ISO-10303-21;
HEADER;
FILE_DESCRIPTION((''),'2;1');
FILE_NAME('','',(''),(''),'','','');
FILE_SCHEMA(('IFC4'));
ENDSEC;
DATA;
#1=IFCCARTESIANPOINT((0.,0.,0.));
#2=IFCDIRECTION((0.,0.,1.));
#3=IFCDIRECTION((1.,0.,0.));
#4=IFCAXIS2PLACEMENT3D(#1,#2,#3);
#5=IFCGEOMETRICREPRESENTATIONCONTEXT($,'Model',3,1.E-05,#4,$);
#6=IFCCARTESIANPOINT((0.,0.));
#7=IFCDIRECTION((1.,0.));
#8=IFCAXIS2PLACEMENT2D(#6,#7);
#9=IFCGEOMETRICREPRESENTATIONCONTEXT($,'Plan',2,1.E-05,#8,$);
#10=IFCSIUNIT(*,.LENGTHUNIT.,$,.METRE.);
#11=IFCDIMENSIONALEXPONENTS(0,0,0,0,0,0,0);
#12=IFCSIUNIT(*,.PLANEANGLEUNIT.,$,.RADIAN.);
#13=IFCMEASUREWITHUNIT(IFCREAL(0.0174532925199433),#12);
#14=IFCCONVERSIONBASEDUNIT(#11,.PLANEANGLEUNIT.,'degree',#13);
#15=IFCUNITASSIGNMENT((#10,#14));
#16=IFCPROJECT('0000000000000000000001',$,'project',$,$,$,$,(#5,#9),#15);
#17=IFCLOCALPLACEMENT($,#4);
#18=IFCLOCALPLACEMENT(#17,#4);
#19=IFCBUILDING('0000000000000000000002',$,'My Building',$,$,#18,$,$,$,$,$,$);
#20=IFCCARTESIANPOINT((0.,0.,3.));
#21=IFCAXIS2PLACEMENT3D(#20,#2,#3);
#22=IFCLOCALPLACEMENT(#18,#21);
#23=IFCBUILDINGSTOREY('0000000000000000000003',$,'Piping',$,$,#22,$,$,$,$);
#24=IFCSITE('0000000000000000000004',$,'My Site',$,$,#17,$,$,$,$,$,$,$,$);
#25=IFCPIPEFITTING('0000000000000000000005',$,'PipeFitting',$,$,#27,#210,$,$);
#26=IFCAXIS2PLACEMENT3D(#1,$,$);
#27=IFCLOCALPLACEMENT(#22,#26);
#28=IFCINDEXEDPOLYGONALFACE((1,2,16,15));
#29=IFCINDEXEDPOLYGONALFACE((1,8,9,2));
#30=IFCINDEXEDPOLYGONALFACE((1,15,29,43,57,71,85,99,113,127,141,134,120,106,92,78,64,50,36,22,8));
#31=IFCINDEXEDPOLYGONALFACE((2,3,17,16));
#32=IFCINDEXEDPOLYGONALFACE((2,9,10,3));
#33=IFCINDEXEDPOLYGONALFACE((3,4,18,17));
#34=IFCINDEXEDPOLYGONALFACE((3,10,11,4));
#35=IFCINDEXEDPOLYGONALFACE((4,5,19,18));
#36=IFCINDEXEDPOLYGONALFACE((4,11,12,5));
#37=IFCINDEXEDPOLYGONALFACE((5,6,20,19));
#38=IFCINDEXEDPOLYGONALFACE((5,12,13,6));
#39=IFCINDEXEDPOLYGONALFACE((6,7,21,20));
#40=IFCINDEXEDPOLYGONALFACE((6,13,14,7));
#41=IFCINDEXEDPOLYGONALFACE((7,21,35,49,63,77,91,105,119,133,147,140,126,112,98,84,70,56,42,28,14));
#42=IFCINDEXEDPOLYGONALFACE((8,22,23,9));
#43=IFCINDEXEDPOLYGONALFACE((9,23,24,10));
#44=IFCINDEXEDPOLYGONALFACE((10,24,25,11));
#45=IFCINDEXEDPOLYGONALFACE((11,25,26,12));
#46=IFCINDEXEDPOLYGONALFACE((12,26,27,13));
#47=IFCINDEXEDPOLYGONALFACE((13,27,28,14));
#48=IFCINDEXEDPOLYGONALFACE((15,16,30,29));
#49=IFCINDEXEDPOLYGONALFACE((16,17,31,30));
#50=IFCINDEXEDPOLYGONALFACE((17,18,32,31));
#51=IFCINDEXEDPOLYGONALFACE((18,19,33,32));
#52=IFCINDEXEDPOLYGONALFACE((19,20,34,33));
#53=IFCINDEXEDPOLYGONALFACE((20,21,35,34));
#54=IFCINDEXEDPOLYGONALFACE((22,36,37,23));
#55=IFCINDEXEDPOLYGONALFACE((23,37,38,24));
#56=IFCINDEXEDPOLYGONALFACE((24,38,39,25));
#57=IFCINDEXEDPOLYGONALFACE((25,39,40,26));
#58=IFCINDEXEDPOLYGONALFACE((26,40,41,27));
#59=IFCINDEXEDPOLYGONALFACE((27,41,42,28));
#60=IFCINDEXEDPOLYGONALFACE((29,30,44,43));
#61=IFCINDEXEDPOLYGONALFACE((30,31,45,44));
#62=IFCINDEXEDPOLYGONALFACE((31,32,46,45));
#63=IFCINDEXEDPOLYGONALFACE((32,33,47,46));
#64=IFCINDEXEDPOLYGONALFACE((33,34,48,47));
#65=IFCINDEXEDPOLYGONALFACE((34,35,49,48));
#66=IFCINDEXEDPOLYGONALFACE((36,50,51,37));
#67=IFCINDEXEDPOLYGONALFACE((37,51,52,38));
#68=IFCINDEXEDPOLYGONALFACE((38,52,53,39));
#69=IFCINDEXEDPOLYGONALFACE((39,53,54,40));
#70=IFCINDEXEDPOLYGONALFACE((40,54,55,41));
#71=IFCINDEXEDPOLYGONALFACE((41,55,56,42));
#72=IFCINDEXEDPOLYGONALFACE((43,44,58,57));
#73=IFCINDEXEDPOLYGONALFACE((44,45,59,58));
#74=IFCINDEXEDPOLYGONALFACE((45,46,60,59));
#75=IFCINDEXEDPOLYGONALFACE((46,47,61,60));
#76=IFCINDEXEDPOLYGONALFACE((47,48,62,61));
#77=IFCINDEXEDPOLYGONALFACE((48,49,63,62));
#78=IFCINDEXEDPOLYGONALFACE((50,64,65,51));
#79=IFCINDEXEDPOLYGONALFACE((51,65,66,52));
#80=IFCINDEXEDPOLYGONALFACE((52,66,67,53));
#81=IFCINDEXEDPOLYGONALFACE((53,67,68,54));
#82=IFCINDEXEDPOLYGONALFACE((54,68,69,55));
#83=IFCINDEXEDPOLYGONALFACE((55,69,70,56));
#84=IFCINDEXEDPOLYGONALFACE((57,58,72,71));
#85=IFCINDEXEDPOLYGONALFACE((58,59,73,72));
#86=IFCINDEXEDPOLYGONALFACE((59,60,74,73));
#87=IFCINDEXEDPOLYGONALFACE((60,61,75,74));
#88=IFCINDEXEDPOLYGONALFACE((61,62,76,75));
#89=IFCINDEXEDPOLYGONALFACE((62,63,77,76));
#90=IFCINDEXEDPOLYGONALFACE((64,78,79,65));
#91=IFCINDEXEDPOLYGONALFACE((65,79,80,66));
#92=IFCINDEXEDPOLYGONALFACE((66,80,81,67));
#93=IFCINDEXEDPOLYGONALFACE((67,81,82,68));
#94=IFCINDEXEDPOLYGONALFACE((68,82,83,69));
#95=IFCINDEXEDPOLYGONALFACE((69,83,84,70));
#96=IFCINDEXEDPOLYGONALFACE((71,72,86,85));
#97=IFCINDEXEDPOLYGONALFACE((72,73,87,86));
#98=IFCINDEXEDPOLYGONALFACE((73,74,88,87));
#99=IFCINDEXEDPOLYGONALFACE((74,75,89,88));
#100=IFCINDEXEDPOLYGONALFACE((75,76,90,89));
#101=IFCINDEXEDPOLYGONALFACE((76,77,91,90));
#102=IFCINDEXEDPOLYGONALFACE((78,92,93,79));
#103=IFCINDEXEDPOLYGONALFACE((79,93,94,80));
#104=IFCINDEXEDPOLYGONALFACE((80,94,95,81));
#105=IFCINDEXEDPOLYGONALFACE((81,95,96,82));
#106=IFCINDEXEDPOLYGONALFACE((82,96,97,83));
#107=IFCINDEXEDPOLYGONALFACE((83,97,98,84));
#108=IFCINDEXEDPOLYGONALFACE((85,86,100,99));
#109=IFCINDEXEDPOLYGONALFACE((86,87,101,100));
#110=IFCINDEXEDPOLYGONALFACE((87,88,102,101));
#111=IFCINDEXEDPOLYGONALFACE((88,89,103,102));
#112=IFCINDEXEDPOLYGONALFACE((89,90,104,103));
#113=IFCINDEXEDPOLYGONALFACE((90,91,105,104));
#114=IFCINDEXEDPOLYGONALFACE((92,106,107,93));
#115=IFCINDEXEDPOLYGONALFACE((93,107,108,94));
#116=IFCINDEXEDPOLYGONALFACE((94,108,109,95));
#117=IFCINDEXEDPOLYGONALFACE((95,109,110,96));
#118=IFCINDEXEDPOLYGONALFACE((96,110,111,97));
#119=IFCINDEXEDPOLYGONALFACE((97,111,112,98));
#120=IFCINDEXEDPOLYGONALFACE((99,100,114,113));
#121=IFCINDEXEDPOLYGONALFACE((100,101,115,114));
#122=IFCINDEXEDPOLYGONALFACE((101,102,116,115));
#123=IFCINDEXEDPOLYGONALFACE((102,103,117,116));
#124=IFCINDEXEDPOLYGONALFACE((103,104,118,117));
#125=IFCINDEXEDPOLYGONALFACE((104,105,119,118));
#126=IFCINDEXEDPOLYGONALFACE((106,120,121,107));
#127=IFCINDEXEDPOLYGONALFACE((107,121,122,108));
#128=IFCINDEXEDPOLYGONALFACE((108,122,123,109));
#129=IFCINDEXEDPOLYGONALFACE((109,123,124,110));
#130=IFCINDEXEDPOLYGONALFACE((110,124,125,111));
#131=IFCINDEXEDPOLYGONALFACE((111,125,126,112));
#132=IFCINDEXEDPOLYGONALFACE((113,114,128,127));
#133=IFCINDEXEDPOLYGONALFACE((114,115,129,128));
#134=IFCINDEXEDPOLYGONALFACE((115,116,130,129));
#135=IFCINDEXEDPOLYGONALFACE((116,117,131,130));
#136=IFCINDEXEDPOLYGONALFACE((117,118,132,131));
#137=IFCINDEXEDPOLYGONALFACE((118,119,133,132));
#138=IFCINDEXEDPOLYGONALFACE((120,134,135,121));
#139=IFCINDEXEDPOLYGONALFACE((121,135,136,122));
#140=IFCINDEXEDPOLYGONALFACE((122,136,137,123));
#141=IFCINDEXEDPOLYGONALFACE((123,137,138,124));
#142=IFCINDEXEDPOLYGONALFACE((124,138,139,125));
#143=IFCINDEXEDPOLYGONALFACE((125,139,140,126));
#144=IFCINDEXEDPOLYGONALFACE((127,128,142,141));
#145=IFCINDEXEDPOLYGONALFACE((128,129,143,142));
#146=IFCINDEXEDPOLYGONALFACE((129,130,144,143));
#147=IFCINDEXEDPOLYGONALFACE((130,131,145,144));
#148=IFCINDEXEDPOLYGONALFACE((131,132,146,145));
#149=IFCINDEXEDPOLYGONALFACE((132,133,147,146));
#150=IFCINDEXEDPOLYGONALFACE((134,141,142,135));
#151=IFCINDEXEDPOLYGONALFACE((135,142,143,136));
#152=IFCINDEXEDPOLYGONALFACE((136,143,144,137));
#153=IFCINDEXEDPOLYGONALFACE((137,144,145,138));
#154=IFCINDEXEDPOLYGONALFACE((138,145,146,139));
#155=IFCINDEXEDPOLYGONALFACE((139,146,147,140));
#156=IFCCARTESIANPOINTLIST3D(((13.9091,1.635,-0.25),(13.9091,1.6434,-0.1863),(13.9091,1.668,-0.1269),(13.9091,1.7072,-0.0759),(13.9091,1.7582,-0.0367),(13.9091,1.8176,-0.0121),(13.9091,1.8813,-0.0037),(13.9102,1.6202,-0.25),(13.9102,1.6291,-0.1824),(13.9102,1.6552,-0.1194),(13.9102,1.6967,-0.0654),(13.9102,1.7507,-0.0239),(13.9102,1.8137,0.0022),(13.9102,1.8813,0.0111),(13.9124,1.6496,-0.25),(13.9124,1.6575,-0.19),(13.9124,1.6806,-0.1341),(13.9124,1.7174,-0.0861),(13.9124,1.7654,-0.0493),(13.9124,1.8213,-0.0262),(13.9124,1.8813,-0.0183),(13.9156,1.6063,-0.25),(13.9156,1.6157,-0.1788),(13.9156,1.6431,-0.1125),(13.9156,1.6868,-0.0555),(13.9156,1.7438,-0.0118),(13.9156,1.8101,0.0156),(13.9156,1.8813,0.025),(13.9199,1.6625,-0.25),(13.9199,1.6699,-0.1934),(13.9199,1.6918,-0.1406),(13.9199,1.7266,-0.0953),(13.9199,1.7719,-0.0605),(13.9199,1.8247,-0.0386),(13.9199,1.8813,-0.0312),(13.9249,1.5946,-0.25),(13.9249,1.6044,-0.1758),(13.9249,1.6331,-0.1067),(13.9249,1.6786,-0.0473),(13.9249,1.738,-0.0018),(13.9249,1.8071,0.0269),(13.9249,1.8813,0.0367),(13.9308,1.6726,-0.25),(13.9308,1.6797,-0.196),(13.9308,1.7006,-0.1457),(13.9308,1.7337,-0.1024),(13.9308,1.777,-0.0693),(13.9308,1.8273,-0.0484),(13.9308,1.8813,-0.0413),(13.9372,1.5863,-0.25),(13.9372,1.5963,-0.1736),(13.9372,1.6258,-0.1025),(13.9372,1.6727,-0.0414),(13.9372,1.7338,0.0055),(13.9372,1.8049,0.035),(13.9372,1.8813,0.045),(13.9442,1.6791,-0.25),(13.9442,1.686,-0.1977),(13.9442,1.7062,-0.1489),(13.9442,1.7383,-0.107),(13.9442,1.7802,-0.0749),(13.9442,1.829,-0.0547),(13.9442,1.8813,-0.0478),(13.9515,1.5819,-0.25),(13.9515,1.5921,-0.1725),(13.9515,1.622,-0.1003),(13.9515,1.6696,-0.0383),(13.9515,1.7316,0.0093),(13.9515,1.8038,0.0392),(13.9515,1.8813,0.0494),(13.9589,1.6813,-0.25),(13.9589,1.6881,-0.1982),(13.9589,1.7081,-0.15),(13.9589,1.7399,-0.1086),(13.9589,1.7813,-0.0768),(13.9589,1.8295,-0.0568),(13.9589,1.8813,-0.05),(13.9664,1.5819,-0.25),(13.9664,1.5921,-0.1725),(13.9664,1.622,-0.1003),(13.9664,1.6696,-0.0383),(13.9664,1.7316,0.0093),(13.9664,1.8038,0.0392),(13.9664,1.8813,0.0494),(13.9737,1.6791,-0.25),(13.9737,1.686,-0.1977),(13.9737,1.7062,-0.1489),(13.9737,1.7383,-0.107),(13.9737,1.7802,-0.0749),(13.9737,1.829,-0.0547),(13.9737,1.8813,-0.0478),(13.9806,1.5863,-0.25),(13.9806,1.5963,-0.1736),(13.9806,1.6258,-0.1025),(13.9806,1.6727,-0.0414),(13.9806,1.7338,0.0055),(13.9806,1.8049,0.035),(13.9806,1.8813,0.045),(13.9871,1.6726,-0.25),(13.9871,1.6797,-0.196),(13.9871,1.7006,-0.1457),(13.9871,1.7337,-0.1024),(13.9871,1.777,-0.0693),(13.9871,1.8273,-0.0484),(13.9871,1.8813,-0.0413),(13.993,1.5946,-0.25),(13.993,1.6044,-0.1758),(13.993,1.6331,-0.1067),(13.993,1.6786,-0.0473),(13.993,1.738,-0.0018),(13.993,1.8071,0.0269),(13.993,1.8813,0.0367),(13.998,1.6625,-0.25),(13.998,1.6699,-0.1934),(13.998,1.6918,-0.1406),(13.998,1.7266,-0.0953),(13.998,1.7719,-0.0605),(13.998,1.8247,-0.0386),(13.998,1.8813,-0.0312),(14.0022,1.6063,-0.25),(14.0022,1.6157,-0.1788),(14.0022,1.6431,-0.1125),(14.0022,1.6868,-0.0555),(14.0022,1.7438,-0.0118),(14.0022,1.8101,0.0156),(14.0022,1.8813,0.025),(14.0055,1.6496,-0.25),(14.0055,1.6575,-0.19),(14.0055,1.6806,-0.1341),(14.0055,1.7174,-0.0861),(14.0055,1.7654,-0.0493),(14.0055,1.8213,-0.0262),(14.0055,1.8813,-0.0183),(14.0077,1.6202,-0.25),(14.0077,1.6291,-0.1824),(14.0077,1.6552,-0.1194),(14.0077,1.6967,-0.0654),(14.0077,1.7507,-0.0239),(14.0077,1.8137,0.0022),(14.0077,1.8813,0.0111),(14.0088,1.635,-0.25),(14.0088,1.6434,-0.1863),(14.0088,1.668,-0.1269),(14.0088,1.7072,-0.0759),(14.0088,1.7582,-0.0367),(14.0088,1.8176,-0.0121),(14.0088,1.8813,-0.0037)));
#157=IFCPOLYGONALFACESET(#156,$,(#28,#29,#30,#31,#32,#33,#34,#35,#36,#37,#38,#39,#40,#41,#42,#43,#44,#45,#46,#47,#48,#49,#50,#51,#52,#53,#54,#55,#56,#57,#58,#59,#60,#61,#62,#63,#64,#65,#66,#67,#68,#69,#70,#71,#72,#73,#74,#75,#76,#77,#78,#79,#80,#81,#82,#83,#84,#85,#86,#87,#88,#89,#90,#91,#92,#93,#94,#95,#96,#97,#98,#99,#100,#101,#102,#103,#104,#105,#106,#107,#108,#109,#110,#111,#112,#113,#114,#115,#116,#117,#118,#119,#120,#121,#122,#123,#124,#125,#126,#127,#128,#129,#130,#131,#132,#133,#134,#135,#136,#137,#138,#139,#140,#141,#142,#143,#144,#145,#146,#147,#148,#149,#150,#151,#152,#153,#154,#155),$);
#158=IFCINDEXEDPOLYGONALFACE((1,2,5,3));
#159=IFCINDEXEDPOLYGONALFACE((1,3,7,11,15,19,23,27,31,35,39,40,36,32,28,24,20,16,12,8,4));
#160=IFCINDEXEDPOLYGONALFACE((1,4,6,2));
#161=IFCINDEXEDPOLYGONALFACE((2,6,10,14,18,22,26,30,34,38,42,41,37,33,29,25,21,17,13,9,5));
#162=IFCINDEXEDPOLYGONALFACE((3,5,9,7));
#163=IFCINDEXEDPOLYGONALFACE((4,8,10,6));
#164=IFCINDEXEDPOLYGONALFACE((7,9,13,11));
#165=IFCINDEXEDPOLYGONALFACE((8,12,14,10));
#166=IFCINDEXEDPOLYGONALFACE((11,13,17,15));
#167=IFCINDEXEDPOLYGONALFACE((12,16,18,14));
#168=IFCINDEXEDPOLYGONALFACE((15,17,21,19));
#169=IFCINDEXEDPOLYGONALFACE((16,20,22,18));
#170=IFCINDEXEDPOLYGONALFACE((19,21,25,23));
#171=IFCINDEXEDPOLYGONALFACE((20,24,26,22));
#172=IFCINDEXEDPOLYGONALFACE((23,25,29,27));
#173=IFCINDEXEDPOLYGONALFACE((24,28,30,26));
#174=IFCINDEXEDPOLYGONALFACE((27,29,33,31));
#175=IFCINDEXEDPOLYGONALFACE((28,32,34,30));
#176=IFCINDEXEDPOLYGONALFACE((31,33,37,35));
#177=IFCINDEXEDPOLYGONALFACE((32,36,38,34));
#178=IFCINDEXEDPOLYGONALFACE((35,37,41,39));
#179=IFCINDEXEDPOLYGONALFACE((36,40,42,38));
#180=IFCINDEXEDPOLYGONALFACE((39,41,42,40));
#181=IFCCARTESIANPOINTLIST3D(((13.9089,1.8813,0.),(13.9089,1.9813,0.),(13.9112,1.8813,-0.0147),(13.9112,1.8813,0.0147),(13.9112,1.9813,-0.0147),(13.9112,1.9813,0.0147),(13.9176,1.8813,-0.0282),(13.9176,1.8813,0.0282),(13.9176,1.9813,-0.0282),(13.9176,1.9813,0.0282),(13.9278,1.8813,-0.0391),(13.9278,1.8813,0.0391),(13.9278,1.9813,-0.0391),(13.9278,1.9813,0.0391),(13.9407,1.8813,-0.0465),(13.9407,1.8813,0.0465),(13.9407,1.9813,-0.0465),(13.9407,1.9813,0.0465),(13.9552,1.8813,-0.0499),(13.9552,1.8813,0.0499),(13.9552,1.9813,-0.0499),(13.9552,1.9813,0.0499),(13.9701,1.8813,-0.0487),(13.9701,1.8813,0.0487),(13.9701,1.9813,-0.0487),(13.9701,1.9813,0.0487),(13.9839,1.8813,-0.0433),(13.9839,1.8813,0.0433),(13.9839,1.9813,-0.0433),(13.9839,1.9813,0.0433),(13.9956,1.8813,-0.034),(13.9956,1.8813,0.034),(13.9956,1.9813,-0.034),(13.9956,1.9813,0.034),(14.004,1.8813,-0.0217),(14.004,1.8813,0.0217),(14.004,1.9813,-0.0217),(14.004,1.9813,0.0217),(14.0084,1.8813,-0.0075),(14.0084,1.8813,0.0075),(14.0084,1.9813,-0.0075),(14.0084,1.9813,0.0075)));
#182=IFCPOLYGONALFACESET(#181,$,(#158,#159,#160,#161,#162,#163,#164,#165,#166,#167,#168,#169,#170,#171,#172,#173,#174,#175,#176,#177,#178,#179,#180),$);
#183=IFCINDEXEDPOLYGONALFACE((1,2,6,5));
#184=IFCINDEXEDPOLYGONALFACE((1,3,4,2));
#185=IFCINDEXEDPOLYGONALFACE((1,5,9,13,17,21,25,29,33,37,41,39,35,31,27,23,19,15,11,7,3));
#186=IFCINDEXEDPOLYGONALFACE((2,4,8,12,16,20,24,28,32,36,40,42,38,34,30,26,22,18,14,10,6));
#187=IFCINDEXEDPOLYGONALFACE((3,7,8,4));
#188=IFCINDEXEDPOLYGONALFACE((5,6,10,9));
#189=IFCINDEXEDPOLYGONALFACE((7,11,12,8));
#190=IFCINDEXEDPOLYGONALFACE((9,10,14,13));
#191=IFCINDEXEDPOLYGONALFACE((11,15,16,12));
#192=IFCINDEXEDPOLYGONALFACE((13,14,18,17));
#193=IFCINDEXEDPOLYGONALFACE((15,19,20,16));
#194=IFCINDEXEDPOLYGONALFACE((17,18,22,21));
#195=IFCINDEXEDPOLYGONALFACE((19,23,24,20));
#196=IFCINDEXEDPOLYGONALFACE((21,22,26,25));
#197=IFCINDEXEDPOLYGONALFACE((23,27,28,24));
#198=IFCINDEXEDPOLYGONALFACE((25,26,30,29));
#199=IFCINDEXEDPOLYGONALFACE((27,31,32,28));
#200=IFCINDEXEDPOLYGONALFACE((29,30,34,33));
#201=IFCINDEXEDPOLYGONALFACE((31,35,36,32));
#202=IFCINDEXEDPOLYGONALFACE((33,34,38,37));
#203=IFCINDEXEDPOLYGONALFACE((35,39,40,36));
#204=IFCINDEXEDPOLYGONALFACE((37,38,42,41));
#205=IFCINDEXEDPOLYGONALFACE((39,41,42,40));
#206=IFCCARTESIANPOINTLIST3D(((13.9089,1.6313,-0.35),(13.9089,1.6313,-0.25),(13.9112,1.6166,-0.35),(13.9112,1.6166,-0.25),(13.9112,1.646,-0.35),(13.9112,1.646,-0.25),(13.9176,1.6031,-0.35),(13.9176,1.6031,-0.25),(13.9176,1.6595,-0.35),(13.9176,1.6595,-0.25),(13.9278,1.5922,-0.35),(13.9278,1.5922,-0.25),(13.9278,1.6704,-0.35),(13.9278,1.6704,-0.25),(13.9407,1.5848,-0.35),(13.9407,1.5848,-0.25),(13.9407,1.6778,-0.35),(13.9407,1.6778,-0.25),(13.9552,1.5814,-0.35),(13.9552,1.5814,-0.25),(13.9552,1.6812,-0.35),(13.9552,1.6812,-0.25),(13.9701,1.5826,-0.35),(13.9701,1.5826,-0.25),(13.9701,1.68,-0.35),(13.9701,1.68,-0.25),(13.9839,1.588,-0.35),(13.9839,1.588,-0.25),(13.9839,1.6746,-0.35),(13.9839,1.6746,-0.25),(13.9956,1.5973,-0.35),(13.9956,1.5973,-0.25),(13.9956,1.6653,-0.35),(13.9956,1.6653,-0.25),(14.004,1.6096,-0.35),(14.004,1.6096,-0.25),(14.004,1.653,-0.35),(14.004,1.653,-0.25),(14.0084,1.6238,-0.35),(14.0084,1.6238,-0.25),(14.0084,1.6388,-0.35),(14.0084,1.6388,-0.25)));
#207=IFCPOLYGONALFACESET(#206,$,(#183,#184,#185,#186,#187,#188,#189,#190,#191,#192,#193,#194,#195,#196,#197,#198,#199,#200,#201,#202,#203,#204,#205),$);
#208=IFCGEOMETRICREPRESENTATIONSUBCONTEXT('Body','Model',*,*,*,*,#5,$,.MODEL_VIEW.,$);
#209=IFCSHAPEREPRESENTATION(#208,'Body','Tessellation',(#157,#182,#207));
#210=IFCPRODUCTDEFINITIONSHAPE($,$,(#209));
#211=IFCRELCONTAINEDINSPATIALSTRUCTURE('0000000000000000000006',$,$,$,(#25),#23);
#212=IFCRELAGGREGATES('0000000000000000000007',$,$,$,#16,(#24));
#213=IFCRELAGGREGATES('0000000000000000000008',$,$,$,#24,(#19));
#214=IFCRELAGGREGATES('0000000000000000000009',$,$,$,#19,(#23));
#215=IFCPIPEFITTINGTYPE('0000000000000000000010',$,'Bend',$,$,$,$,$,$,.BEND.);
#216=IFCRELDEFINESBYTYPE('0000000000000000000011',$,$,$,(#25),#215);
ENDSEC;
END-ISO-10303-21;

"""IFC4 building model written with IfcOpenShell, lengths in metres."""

from ifc_helpers import new_model, entity, si_unit, converted_unit, frame, origin_with_axes, origin_2d_with_axis, place, context, subcontext, project, spatial, circle, extrude, source, transform, mapped, type_object, type_shapes, element, save


model = new_model("IFC4")

# Units and contexts
model_context = context("Model", 3, precision=1e-05, world=origin_with_axes())
plan_context = context("Plan", 2, precision=1e-05, world=origin_2d_with_axis())
body_context = subcontext(model_context, "Body", "Model", "MODEL_VIEW")
ifc_project = project(units=[si_unit("LENGTHUNIT", "METRE"), converted_unit("PLANEANGLEUNIT", "degree", entity("IfcReal", 0.0174532925199433), si_unit("PLANEANGLEUNIT", "RADIAN"), dimensions=[0, 0, 0, 0, 0, 0, 0])], contexts=[model_context, plan_context])

# Site, building, storey
site_placement = place(None, origin_with_axes())
site = spatial("IfcSite", under=ifc_project, at=site_placement, Name="My Site")
building_placement = place(site_placement, origin_with_axes())
building = spatial("IfcBuilding", under=site, at=building_placement, Name="My Building")
storey_placement = place(building_placement, frame((0.0, 0.0, 3.0), z_axis=(0.0, 0.0, 1.0), x_axis=(1.0, 0.0, 0.0)))
storey = spatial("IfcBuildingStorey", under=building, at=storey_placement, Name="Piping")

# Pipe fitting
pipe_fitting_type = type_object("IfcPipeFittingType", Name="Bend", PredefinedType="BEND")
shared_shape = source(origin_with_axes(), body_context, "Body", "SolidModel", [
    entity("IfcSweptDiskSolid", entity("IfcIndexedPolyCurve", entity("IfcCartesianPointList3D", [[0.0, 0.0, -0.1], [0.0, -0.0732, -0.2768], [0.0, -0.25, -0.35]]), [entity("IfcArcIndex", [1, 2, 3])]), 0.05),
    extrude(circle(Radius=0.05), origin_with_axes(), (0.0, 0.0, -1.0), 0.1),
    extrude(circle(Radius=0.05), frame((0.0, -0.25, -0.35), z_axis=(0.0, -1.0, 0.0), x_axis=(1.0, 0.0, 0.0)), (0.0, 0.0, 1.0), 0.1),
])
type_shapes(pipe_fitting_type, [shared_shape])
for number, where, z_axis, x_axis, name in (
    (1, (13.9589, 1.9813, 0.0), (0.0, 1.0, 0.0), (-1.0, 0.0, 0.0), "PipeFitting"),
):
    element("IfcPipeFitting", number, at=place(storey_placement, frame(where, z_axis=z_axis, x_axis=x_axis)), inside=storey, type_object=pipe_fitting_type, Name=name, context=body_context, shape_type="MappedRepresentation", body=[
        mapped(shared_shape, transform((0.0, 0.0, 0.0), x_axis=(1.0, 0.0, 0.0), y_axis=(0.0, 1.0, 0.0), z_axis=(0.0, 0.0, 1.0), scale=1.0)),
    ])

save(model, "model.ifc")
